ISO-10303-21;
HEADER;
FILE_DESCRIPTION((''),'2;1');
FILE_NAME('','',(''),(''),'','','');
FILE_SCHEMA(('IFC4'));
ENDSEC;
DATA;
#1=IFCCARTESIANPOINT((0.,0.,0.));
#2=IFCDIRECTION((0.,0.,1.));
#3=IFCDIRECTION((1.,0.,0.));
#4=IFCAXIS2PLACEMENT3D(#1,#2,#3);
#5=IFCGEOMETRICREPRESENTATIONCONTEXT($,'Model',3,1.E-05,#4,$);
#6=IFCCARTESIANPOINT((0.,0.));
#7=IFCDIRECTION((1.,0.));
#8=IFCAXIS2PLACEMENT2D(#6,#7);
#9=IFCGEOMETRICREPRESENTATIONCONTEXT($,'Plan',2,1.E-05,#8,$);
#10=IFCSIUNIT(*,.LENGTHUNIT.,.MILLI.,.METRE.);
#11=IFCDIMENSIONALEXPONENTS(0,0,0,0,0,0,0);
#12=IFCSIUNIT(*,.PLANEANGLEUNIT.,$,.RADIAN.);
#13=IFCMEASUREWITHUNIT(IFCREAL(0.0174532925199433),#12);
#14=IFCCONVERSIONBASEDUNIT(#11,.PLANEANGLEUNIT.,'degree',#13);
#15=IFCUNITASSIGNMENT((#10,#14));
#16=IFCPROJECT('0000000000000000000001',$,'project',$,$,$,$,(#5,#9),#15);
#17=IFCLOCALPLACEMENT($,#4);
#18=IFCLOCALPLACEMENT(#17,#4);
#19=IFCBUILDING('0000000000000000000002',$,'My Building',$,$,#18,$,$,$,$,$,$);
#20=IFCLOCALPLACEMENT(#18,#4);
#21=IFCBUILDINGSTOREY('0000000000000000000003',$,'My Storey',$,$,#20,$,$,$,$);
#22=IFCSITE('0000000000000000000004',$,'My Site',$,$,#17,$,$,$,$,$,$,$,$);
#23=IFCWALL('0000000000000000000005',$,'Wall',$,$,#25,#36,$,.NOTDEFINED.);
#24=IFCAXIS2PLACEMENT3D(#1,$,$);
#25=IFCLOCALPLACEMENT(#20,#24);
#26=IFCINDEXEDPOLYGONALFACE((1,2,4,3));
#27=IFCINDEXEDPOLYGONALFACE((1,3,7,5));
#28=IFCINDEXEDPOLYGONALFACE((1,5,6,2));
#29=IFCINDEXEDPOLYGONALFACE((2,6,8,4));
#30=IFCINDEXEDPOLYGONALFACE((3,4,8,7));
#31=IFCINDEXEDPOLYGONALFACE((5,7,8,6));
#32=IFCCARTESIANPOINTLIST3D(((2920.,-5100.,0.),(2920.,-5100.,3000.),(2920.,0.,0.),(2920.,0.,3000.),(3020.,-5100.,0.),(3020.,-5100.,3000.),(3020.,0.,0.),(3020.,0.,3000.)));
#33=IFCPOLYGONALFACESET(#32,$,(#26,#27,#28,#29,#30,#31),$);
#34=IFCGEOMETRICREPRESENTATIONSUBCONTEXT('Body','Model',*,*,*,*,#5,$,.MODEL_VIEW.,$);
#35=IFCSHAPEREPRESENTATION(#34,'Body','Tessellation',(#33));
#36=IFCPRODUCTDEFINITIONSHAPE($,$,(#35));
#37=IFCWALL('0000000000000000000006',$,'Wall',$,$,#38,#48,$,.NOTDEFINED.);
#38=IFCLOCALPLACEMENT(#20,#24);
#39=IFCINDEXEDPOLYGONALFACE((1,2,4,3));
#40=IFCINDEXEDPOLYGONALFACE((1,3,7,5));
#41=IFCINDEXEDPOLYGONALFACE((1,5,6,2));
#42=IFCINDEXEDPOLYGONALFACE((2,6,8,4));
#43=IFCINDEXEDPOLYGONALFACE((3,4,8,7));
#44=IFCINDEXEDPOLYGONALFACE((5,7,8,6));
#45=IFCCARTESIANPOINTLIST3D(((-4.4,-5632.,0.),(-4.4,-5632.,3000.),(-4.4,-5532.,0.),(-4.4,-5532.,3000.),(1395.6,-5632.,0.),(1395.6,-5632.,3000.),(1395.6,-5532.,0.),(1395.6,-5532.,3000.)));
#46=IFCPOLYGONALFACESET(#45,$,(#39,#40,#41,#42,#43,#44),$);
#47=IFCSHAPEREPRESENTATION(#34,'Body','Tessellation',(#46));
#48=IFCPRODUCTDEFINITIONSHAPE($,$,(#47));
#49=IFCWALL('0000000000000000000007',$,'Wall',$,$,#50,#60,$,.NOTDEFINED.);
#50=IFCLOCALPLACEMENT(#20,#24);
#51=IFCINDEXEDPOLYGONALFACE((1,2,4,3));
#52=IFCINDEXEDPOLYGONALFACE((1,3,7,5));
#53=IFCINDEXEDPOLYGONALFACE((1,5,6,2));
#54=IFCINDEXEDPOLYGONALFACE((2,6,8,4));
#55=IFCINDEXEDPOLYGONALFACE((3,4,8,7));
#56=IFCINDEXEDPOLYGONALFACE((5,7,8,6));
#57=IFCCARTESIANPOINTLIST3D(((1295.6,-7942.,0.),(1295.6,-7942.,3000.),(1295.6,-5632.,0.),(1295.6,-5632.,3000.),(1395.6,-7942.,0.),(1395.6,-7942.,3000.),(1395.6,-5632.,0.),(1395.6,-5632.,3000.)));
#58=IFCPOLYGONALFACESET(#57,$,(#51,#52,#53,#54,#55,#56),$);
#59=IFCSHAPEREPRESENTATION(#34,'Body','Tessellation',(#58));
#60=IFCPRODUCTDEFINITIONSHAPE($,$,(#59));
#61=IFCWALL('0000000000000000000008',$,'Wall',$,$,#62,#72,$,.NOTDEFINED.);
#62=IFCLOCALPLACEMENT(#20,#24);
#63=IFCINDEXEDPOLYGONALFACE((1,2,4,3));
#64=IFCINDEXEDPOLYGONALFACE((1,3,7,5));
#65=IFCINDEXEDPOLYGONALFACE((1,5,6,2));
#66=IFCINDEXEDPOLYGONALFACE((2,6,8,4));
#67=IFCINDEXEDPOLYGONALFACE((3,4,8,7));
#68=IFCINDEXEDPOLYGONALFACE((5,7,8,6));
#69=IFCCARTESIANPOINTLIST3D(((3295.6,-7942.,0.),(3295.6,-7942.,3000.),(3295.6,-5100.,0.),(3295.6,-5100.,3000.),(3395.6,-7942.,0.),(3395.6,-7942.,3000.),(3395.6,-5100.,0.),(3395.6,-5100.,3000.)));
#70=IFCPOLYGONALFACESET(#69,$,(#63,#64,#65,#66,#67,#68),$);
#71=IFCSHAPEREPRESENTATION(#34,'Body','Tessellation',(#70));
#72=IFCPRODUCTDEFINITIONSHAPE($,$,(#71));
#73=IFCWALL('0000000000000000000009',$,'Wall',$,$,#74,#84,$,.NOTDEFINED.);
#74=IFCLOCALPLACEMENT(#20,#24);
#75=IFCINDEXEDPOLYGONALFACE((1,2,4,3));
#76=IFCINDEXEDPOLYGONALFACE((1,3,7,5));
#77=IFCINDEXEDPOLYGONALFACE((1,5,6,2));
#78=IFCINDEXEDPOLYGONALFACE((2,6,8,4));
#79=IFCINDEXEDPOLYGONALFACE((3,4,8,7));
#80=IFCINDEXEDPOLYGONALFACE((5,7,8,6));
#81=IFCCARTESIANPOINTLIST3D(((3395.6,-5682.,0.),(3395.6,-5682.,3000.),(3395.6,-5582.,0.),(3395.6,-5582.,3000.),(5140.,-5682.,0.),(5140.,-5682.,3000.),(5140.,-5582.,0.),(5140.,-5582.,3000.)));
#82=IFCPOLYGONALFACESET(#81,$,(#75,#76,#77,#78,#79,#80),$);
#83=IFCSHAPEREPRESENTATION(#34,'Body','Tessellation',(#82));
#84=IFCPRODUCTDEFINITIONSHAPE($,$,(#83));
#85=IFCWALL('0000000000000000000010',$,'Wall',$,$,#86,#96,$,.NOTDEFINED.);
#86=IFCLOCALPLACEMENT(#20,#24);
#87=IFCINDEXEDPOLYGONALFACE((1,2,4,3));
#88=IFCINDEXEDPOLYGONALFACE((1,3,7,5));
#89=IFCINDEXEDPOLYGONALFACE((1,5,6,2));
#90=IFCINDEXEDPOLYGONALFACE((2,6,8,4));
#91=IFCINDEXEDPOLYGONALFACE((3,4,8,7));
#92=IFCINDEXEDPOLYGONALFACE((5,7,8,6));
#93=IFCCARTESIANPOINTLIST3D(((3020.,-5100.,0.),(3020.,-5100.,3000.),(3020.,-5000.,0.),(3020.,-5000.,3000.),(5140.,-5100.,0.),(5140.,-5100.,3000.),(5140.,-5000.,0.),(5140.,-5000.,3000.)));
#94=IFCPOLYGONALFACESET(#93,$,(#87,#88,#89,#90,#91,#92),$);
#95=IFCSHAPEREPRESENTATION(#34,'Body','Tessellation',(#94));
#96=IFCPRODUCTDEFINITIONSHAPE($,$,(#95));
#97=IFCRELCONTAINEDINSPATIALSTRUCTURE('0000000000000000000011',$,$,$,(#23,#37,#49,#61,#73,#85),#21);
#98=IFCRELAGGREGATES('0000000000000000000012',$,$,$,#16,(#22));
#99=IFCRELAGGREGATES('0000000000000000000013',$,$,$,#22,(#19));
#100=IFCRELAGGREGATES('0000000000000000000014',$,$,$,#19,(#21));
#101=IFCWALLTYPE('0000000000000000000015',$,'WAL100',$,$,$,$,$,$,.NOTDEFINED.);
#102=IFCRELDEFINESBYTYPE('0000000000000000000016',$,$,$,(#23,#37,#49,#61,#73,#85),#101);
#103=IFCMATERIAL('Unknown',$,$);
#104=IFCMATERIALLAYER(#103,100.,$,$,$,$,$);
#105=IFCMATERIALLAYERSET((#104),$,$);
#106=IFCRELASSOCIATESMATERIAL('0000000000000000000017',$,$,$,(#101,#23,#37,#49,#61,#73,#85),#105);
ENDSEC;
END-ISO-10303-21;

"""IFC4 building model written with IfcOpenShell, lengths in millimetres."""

from ifc_helpers import new_model, entity, si_unit, converted_unit, frame, origin_with_axes, origin_2d_with_axis, place, context, subcontext, project, spatial, indexed_curve, outline, extrude, material, layer, layer_set, layer_usage, type_object, element, save


model = new_model("IFC4")

# Units and contexts
model_context = context("Model", 3, precision=1e-05, world=origin_with_axes())
plan_context = context("Plan", 2, precision=1e-05, world=origin_2d_with_axis())
body_context_1 = subcontext(model_context, "Body", "Model", "MODEL_VIEW")
ifc_project = project(units=[si_unit("LENGTHUNIT", "METRE", prefix="MILLI"), converted_unit("PLANEANGLEUNIT", "degree", entity("IfcReal", 0.0174532925199433), si_unit("PLANEANGLEUNIT", "RADIAN"), dimensions=[0, 0, 0, 0, 0, 0, 0])], contexts=[model_context, plan_context])

# Site, building, storey
site_placement = place(None, origin_with_axes())
site = spatial("IfcSite", under=ifc_project, at=site_placement, Name="My Site")
building_placement = place(site_placement, origin_with_axes())
building = spatial("IfcBuilding", under=site, at=building_placement, Name="My Building")
storey_placement = place(building_placement, origin_with_axes())
storey = spatial("IfcBuildingStorey", under=building, at=storey_placement, Name="My Storey")

# Walls
ifc_material = material(Name="Unknown")
ifc_layer_1 = layer(ifc_material, 100.0)
ifc_layer_set_1 = layer_set([ifc_layer_1])
ifc_layer_usage_1 = layer_usage(ifc_layer_set_1, "AXIS2", "POSITIVE", 0.0)
wall_type_1 = type_object("IfcWallType", Name="WAL100", PredefinedType="NOTDEFINED", material=ifc_layer_set_1)
wall_1_placement = place(storey_placement, frame((2920.0, 0.0, 0.0), z_axis=(0.0, 0.0, 1.0), x_axis=(0.0, -1.0, 0.0)))
element("IfcWall", 1, at=wall_1_placement, inside=storey, type_object=wall_type_1, material=ifc_layer_usage_1, Name="Wall", PredefinedType="NOTDEFINED", context=body_context_1, shape_type="SweptSolid", body=[
    extrude(outline(indexed_curve([(0.0, 0.0), (0.0, 100.0), (5100.0, 100.0), (5100.0, 0.0), (0.0, 0.0)], self_intersect=False)), origin_with_axes(), (0.0, 0.0, 1.0), 3000.0),
])
ifc_layer_usage_2 = layer_usage(ifc_layer_set_1, "AXIS2", "POSITIVE", 0.0)
wall_2_placement = place(storey_placement, frame((1395.6, -5532.0, 0.0), z_axis=(0.0, 0.0, 1.0), x_axis=(-1.0, 0.000001, 0.0)))
element("IfcWall", 2, at=wall_2_placement, inside=storey, type_object=wall_type_1, material=ifc_layer_usage_2, Name="Wall", PredefinedType="NOTDEFINED", context=body_context_1, shape_type="SweptSolid", body=[
    extrude(outline(indexed_curve([(0.0, 0.0), (0.0, 100.0), (1400.0, 100.0), (1400.0, 0.0), (0.0, 0.0)], self_intersect=False)), origin_with_axes(), (0.0, 0.0, 1.0), 3000.0),
])
ifc_layer_usage_3 = layer_usage(ifc_layer_set_1, "AXIS2", "POSITIVE", 0.0)
wall_3_placement = place(storey_placement, frame((1295.6, -5632.0, 0.0), z_axis=(0.0, 0.0, 1.0), x_axis=(-0.000001, -1.0, 0.0)))
element("IfcWall", 3, at=wall_3_placement, inside=storey, type_object=wall_type_1, material=ifc_layer_usage_3, Name="Wall", PredefinedType="NOTDEFINED", context=body_context_1, shape_type="SweptSolid", body=[
    extrude(outline(indexed_curve([(0.0, 0.0), (0.0, 100.0), (2310.0, 100.0), (2310.0, 0.0), (0.0, 0.0)], self_intersect=False)), origin_with_axes(), (0.0, 0.0, 1.0), 3000.0),
])
ifc_layer_usage_4 = layer_usage(ifc_layer_set_1, "AXIS2", "POSITIVE", 0.0)
wall_4_placement = place(storey_placement, frame((3295.6, -5100.0, 0.0), z_axis=(0.0, 0.0, 1.0), x_axis=(-0.000001, -1.0, 0.0)))
element("IfcWall", 4, at=wall_4_placement, inside=storey, type_object=wall_type_1, material=ifc_layer_usage_4, Name="Wall", PredefinedType="NOTDEFINED", context=body_context_1, shape_type="SweptSolid", body=[
    extrude(outline(indexed_curve([(0.0, 0.0), (0.0, 100.0), (2842.0, 100.0), (2842.0, 0.0), (0.0, 0.0)], self_intersect=False)), origin_with_axes(), (0.0, 0.0, 1.0), 3000.0),
])
ifc_layer_usage_5 = layer_usage(ifc_layer_set_1, "AXIS2", "POSITIVE", 0.0)
wall_5_placement = place(storey_placement, frame((3395.6, -5682.0, 0.0), z_axis=(0.0, 0.0, 1.0), x_axis=(1.0, -0.000001, 0.0)))
element("IfcWall", 5, at=wall_5_placement, inside=storey, type_object=wall_type_1, material=ifc_layer_usage_5, Name="Wall", PredefinedType="NOTDEFINED", context=body_context_1, shape_type="SweptSolid", body=[
    extrude(outline(indexed_curve([(0.0, 0.0), (0.0, 100.0), (1744.4, 100.0), (1744.4, 0.0), (0.0, 0.0)], self_intersect=False)), origin_with_axes(), (0.0, 0.0, 1.0), 3000.0),
])
ifc_layer_usage_6 = layer_usage(ifc_layer_set_1, "AXIS2", "POSITIVE", 0.0)
wall_6_placement = place(storey_placement, frame((3020.0, -5100.0, 0.0), z_axis=(0.0, 0.0, 1.0), x_axis=(1.0, 0.0, 0.0)))
element("IfcWall", 6, at=wall_6_placement, inside=storey, type_object=wall_type_1, material=ifc_layer_usage_6, Name="Wall", PredefinedType="NOTDEFINED", context=body_context_1, shape_type="SweptSolid", body=[
    extrude(outline(indexed_curve([(0.0, 0.0), (0.0, 100.0), (2120.0, 100.0), (2120.0, 0.0), (0.0, 0.0)], self_intersect=False)), origin_with_axes(), (0.0, 0.0, 1.0), 3000.0),
])

save(model, "model.ifc")
